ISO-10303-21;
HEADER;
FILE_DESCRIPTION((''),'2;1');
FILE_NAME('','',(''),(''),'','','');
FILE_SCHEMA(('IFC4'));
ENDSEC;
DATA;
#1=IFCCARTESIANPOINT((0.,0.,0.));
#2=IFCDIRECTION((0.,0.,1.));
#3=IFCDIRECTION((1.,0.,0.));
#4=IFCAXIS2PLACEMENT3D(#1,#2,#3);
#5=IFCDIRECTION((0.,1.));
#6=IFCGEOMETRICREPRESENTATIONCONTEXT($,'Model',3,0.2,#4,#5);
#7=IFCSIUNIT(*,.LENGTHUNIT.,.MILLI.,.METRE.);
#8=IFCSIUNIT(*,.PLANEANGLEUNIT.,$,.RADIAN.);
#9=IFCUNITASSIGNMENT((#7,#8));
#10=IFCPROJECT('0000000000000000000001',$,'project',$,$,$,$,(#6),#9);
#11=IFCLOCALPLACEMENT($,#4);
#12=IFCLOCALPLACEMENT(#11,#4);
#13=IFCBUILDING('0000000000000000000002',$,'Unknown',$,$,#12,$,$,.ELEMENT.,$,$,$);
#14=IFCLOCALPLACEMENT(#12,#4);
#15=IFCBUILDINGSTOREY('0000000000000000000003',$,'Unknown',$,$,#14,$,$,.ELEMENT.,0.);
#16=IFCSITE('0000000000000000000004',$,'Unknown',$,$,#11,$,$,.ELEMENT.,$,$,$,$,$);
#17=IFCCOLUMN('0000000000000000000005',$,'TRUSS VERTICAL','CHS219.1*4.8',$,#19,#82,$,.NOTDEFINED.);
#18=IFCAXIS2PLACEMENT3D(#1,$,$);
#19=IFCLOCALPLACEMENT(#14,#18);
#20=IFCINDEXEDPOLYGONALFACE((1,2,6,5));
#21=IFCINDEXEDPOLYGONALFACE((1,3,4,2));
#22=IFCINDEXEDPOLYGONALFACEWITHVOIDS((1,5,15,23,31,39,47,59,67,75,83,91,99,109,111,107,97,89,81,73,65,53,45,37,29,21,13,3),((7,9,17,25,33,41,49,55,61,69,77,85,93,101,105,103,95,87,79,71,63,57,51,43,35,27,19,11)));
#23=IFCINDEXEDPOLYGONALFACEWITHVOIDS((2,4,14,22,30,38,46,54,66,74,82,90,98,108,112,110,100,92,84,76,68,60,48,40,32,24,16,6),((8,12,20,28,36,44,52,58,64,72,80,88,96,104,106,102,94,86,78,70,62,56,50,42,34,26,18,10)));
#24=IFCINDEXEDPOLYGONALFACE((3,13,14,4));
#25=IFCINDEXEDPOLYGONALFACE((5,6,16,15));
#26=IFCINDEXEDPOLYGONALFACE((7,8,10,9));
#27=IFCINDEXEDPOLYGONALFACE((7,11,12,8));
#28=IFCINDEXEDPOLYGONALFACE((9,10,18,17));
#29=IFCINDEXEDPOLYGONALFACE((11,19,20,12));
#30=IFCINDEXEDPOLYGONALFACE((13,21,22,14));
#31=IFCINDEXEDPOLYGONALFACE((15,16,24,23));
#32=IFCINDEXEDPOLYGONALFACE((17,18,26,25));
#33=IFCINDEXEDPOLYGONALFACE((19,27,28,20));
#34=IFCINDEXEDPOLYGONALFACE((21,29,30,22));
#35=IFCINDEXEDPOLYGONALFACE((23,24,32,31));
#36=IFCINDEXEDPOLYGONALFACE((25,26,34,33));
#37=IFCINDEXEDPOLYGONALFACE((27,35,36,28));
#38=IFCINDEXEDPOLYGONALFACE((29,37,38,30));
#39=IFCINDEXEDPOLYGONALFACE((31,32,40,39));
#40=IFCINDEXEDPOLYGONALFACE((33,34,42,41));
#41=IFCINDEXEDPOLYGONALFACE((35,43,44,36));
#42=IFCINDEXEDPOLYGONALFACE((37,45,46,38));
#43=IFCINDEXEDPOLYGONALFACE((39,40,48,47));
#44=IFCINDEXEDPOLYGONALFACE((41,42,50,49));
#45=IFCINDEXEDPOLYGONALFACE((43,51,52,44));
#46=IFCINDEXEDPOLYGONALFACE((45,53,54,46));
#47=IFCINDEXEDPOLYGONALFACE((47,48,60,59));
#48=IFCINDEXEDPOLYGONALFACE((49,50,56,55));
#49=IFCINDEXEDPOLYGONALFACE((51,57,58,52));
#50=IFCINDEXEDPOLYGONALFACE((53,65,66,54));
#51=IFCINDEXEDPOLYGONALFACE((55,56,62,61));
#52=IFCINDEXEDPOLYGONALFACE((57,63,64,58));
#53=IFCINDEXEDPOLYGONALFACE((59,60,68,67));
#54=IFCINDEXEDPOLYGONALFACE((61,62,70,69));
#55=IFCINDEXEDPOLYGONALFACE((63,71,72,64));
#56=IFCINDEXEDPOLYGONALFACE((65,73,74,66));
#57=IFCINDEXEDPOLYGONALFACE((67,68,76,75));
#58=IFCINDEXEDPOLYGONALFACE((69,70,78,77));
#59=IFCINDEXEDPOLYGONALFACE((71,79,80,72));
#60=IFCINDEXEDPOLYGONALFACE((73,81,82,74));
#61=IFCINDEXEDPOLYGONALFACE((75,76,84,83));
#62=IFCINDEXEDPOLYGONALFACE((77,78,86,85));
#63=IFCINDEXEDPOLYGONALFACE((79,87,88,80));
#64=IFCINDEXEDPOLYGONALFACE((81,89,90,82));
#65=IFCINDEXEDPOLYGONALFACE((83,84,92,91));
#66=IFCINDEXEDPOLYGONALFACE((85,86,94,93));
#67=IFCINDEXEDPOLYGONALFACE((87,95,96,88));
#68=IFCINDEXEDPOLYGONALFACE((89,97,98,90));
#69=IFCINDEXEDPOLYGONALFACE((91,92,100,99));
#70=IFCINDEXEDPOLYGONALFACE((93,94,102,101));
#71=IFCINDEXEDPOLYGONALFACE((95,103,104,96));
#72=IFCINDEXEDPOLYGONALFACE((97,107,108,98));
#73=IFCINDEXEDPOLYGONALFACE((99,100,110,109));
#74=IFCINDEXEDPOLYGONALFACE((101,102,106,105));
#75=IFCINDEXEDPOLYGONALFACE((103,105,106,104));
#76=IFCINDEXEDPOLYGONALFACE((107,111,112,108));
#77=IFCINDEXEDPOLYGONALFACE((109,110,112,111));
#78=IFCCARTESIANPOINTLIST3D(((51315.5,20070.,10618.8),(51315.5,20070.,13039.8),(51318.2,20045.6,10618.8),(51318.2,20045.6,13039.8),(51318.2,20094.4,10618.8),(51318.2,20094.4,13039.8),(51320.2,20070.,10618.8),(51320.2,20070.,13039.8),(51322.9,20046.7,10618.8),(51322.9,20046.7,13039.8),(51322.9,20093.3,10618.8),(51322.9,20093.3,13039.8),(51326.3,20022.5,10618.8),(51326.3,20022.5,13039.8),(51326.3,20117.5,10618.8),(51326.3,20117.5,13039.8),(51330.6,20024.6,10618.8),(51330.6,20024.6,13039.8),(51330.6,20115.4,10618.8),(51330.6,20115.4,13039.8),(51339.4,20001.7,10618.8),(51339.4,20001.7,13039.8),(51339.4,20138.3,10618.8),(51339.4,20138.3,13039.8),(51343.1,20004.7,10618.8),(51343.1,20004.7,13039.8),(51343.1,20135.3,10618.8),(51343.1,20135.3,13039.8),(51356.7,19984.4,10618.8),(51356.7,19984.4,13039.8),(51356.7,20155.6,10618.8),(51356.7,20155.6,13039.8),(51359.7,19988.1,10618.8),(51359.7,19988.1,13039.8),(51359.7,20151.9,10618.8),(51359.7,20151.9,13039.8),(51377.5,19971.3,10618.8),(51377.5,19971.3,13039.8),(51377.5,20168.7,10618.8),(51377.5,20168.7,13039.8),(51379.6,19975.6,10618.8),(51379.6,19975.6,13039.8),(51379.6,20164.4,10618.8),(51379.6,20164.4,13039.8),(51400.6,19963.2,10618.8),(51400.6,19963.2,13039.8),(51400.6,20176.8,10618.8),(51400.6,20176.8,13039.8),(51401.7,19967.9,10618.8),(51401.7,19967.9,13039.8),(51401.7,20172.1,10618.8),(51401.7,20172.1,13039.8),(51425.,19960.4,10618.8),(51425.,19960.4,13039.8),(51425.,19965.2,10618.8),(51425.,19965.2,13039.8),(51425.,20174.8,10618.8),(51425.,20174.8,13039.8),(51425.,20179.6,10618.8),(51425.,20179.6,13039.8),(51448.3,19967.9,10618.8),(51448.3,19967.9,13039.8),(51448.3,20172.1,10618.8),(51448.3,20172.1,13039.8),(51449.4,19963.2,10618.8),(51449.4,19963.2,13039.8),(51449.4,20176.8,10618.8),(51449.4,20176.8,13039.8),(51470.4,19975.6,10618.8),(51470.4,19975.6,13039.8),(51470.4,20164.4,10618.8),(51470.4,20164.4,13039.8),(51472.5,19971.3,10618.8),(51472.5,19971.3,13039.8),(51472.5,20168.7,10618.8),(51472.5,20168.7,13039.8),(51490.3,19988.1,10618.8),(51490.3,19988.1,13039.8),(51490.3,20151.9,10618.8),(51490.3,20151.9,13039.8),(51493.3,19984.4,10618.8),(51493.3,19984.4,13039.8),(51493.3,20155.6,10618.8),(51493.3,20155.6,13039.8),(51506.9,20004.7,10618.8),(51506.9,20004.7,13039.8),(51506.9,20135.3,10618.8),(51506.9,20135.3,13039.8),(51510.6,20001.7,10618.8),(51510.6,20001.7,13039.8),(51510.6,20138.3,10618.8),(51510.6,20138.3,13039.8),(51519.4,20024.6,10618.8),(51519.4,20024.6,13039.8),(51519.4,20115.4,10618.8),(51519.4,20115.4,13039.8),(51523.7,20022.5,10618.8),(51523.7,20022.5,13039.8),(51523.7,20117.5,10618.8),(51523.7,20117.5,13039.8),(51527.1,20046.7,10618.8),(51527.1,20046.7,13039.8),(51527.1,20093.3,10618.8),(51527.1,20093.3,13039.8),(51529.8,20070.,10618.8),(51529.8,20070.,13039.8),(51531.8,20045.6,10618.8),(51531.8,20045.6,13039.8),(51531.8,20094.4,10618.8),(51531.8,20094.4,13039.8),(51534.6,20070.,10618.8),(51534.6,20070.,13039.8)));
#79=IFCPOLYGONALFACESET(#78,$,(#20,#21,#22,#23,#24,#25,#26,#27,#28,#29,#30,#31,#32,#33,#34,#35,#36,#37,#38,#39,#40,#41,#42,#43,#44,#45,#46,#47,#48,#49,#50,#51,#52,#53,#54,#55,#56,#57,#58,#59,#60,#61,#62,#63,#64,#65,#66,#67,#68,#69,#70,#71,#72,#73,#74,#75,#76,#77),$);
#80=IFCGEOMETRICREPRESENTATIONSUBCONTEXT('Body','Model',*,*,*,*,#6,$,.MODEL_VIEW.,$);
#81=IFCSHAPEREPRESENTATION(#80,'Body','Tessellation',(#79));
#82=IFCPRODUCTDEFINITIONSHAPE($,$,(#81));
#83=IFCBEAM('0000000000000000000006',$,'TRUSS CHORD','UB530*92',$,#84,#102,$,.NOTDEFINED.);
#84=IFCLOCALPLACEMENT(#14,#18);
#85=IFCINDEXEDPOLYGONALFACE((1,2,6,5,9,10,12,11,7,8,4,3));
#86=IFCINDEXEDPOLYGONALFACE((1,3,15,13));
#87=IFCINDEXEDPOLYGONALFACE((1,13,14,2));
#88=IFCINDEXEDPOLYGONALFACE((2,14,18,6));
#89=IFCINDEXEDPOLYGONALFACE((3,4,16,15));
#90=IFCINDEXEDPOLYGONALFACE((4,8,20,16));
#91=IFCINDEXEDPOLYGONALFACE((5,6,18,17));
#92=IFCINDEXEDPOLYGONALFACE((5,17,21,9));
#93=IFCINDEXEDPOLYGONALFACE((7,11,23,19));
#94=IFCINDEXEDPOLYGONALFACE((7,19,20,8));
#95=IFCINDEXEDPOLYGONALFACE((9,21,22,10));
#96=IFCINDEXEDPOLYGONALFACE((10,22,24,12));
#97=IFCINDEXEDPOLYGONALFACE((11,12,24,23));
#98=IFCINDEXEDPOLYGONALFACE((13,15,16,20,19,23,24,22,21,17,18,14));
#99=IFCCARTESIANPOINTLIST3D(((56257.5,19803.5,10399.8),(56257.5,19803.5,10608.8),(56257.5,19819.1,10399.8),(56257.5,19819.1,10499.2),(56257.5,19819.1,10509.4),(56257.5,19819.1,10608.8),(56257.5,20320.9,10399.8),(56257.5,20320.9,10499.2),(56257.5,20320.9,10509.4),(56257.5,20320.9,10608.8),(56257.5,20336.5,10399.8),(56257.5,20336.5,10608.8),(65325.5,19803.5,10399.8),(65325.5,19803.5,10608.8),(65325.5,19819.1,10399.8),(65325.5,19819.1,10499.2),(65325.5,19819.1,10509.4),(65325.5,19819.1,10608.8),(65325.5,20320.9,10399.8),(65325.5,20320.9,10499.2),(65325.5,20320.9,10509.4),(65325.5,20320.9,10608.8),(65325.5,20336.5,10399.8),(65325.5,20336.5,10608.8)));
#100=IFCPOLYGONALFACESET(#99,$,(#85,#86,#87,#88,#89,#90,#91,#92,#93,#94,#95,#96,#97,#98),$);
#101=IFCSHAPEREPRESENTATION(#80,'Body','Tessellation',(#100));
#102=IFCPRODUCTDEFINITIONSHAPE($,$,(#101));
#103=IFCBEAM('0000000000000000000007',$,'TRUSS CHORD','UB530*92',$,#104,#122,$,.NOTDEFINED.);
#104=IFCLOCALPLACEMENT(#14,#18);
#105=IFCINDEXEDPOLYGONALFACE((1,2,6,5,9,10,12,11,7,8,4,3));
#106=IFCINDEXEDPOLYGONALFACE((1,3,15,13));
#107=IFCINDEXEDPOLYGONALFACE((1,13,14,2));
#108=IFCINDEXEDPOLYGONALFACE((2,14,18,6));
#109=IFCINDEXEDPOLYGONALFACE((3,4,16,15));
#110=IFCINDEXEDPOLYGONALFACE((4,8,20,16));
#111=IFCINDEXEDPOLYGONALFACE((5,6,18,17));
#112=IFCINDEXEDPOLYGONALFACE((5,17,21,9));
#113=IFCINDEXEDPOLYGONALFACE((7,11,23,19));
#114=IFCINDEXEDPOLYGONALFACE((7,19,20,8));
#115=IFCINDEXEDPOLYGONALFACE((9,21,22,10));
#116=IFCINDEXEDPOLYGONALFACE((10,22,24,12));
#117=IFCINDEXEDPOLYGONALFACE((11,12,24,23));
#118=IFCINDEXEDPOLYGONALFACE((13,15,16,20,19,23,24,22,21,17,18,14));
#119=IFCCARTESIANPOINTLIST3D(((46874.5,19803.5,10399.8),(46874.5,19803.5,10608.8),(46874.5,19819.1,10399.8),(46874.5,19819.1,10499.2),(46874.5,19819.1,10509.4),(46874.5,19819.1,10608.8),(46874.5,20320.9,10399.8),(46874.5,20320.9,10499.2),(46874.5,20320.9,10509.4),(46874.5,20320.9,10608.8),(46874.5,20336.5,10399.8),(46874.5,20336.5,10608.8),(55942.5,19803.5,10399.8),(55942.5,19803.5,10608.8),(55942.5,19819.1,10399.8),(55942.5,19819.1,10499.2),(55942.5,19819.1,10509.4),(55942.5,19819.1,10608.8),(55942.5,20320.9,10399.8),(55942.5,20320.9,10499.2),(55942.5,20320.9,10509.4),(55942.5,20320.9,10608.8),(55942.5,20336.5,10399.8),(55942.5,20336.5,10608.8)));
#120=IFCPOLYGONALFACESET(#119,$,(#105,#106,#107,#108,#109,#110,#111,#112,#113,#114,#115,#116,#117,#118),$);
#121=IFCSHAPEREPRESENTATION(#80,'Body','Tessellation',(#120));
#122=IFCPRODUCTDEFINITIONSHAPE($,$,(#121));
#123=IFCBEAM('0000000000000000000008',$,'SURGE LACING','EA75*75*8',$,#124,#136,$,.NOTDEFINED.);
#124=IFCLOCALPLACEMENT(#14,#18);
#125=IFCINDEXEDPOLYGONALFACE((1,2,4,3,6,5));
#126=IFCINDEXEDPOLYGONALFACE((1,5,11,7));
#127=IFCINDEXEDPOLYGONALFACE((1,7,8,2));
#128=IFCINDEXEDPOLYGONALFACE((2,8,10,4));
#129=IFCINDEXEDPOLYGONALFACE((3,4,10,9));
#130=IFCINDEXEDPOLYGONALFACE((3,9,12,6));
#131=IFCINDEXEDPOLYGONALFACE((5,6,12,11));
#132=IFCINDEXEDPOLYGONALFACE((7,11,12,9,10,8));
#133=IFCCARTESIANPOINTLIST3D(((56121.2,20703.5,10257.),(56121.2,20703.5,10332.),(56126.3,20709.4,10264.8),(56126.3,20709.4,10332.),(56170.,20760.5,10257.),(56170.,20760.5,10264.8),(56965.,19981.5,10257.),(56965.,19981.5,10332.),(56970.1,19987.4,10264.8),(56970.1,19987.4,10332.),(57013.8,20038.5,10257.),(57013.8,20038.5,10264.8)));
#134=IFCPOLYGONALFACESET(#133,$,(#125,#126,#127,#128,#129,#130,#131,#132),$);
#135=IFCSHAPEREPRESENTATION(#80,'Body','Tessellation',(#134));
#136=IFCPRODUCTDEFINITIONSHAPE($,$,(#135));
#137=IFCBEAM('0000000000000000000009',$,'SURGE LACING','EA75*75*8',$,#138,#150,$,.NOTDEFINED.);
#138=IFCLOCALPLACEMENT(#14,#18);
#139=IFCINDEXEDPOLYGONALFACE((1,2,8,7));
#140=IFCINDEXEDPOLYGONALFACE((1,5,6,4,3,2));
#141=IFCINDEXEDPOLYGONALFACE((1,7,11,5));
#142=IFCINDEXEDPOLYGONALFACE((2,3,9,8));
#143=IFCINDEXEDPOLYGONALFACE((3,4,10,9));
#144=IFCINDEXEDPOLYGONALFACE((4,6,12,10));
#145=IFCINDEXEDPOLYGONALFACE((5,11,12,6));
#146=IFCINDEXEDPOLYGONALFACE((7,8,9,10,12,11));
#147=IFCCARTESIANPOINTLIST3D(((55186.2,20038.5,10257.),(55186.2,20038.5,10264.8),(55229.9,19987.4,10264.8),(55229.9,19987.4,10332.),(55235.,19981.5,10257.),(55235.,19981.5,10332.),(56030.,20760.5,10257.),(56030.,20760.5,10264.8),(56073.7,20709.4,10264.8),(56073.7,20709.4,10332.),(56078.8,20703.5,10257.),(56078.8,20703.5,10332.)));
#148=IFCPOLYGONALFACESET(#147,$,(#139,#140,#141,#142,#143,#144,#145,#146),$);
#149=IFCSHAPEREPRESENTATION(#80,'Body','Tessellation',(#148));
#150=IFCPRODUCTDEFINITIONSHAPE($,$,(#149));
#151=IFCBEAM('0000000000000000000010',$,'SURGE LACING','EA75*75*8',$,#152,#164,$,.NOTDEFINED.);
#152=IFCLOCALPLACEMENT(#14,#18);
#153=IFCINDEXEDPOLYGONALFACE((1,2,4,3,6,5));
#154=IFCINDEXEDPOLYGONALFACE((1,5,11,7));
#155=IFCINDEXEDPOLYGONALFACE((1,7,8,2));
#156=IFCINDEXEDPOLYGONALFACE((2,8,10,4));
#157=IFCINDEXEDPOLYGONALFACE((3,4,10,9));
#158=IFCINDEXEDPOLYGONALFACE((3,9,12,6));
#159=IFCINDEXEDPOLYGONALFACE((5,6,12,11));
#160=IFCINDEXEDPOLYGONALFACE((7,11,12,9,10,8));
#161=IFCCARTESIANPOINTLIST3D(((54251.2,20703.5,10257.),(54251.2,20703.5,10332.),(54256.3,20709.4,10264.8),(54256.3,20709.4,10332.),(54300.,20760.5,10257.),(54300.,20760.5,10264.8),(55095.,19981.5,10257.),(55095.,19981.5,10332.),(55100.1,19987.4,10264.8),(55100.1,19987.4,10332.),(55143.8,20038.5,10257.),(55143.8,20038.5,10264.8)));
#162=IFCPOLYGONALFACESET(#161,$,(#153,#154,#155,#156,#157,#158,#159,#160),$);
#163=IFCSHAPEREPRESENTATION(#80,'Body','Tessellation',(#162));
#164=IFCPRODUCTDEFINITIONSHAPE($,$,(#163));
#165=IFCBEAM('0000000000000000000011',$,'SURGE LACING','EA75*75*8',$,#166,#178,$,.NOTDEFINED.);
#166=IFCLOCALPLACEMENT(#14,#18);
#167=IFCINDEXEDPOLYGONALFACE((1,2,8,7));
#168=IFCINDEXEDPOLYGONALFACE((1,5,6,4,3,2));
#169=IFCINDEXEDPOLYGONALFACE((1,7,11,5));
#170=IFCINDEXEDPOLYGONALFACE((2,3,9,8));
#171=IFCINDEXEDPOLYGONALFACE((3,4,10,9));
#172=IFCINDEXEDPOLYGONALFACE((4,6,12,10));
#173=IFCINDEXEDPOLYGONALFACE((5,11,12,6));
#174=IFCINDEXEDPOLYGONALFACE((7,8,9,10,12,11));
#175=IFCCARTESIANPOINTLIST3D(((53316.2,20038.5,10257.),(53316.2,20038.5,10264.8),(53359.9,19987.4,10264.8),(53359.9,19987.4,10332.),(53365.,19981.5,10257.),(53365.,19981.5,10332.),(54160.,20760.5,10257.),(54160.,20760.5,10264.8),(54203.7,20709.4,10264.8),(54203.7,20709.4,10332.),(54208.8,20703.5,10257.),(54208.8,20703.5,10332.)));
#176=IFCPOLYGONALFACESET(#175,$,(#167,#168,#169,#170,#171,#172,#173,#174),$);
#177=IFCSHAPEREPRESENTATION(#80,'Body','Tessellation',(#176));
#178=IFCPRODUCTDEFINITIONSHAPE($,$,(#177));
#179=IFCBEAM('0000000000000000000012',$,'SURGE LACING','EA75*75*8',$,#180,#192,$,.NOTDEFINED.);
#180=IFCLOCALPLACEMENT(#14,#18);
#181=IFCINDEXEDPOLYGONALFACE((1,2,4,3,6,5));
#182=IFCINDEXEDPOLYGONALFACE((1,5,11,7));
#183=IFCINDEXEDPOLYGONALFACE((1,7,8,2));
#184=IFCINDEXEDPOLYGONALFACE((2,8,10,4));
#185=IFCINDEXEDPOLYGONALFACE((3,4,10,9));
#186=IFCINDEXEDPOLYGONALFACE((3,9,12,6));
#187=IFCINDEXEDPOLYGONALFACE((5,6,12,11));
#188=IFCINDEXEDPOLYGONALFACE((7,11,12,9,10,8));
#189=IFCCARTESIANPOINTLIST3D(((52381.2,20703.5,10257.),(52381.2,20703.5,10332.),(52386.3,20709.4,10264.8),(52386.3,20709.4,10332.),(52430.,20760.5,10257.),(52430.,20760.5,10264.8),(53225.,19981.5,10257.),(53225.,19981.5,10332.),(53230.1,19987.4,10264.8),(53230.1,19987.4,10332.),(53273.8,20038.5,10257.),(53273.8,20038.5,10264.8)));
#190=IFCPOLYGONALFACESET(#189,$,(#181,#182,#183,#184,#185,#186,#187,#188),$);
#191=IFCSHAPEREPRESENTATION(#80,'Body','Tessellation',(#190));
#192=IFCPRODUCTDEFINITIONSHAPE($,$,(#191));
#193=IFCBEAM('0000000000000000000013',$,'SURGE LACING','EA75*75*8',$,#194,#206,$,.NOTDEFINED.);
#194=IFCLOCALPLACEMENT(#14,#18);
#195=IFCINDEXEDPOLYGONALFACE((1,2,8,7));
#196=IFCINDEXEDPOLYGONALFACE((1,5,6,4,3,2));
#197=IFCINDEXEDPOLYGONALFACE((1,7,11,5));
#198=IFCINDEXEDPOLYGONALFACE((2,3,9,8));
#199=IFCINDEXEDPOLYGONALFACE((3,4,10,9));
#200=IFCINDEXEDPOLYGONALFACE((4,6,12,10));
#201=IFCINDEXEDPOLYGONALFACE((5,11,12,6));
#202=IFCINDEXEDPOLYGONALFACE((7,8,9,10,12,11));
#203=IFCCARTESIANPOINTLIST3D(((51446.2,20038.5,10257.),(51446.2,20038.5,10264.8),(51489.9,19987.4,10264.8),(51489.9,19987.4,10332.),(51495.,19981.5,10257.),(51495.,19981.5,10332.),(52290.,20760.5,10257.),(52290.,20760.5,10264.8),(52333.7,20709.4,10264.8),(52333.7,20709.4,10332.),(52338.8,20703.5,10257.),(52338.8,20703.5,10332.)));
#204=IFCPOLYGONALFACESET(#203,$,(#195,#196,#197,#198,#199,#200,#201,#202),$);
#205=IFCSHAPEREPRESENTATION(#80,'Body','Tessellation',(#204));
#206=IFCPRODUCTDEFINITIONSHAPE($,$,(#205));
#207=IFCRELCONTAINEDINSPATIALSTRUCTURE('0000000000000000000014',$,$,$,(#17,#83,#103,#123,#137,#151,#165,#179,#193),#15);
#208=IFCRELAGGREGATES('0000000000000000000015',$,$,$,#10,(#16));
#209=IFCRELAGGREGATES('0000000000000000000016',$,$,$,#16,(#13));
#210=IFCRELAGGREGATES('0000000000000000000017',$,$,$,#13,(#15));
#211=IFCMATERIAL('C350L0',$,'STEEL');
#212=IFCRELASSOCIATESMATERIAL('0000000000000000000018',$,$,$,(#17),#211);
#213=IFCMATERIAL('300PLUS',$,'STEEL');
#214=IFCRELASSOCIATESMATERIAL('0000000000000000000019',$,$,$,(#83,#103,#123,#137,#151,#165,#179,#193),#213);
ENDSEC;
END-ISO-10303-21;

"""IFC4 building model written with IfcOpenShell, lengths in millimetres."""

from ifc_helpers import new_model, si_unit, direction, frame, origin_with_axes, place, context, subcontext, project, spatial, line, indexed_curve, outline, extrude, material, element, save


model = new_model("IFC4")

# Units and contexts
model_context = context("Model", 3, precision=0.2, world=origin_with_axes(), true_north=direction((0.0, 1.0)))
body_context = subcontext(model_context, "Body", "Model", "MODEL_VIEW")
ifc_project = project(units=[si_unit("LENGTHUNIT", "METRE", prefix="MILLI"), si_unit("PLANEANGLEUNIT", "RADIAN")], contexts=[model_context])

# Site, building, storey
site_placement = place(None, origin_with_axes())
site = spatial("IfcSite", under=ifc_project, at=site_placement, Name="Unknown", CompositionType="ELEMENT")
building_placement = place(site_placement, origin_with_axes())
building = spatial("IfcBuilding", under=site, at=building_placement, Name="Unknown", CompositionType="ELEMENT")
storey_placement = place(building_placement, origin_with_axes())
storey = spatial("IfcBuildingStorey", under=building, at=storey_placement, Name="Unknown", CompositionType="ELEMENT", Elevation=0.0)

# Column
ifc_material_1 = material(Name="C350L0", Category="STEEL")
column_placement = place(storey_placement, frame((51425.0, 20070.0, 10618.8), z_axis=(-1.0, 0.0, 0.0), x_axis=(0.0, 0.0, 1.0)))
element("IfcColumn", 1, at=column_placement, inside=storey, material=ifc_material_1, Name="TRUSS VERTICAL", Description="CHS219.1*4.8", PredefinedType="NOTDEFINED", context=body_context, shape_type="SolidModel", body=[
    extrude(outline(indexed_curve([(109.5, 0.0), (106.8, 24.4), (98.7, 47.5), (85.6, 68.3), (68.3, 85.6), (47.5, 98.7), (24.4, 106.8), (0.0, 109.5), (-24.4, 106.8), (-47.5, 98.7), (-68.3, 85.6), (-85.6, 68.3), (-98.7, 47.5), (-106.8, 24.4), (-109.5, 0.0), (-106.8, -24.4), (-98.7, -47.5), (-85.6, -68.3), (-68.3, -85.6), (-47.5, -98.7), (-24.4, -106.8), (0.0, -109.5), (24.4, -106.8), (47.5, -98.7), (68.3, -85.6), (85.6, -68.3), (98.7, -47.5), (106.8, -24.4)], segments=[line(1, 2, 3, 4, 5, 6, 7, 8, 9, 10, 11, 12, 13, 14, 15, 16, 17, 18, 19, 20, 21, 22, 23, 24, 25, 26, 27, 28, 1)]), holes=[indexed_curve([(104.8, 0.0), (102.1, -23.3), (94.4, -45.4), (81.9, -65.3), (65.3, -81.9), (45.4, -94.4), (23.3, -102.1), (0.0, -104.8), (-23.3, -102.1), (-45.4, -94.4), (-65.3, -81.9), (-81.9, -65.3), (-94.4, -45.4), (-102.1, -23.3), (-104.8, 0.0), (-102.1, 23.3), (-94.4, 45.4), (-81.9, 65.3), (-65.3, 81.9), (-45.4, 94.4), (-23.3, 102.1), (0.0, 104.8), (23.3, 102.1), (45.4, 94.4), (65.3, 81.9), (81.9, 65.3), (94.4, 45.4), (102.1, 23.3)], segments=[line(1, 2, 3, 4, 5, 6, 7, 8, 9, 10, 11, 12, 13, 14, 15, 16, 17, 18, 19, 20, 21, 22, 23, 24, 25, 26, 27, 28, 1)])]), frame((0.0, 0.0, 0.0), z_axis=(-1.0, 0.0, 0.0), x_axis=(0.0, 0.0, 1.0)), (0.0, 0.0, -1.0), 2421.0),
])

# Beams
ifc_material_2 = material(Name="300PLUS", Category="STEEL")
for number, where, z_axis, x_axis, name in (
    (2, (56257.5, 20070.0, 10504.3), (0.0, 0.0, 1.0), (1.0, 0.0, 0.0), "TRUSS CHORD"),
    (3, (46874.5, 20070.0, 10504.3), (0.0, 0.0, 1.0), (1.0, 0.0, 0.0), "TRUSS CHORD"),
):
    element("IfcBeam", number, at=place(storey_placement, frame(where, z_axis=z_axis, x_axis=x_axis)), inside=storey, material=ifc_material_2, Name=name, Description="UB530*92", PredefinedType="NOTDEFINED", context=body_context, shape_type="SolidModel", body=[
        extrude(outline(indexed_curve([(-104.5, -266.5), (104.5, -266.5), (104.5, -250.9), (5.1, -250.9), (5.1, 250.9), (104.5, 250.9), (104.5, 266.5), (-104.5, 266.5), (-104.5, 250.9), (-5.1, 250.9), (-5.1, -250.9), (-104.5, -250.9)], segments=[line(1, 2, 3, 4, 5, 6, 7, 8, 9, 10, 11, 12, 1)])), frame((0.0, 0.0, 0.0), z_axis=(-1.0, 0.0, 0.0), x_axis=(0.0, 0.0, 1.0)), (0.0, 0.0, -1.0), 9068.0),
    ])
for number, where, z_axis, x_axis, name in (
    (4, (56145.6, 20732.0, 10294.5), (0.0, 0.0, 1.0), (0.759816, -0.650139, 0.0), "SURGE LACING"),
    (5, (55210.6, 20010.0, 10294.5), (0.0, 0.0, 1.0), (0.759816, 0.650139, 0.0), "SURGE LACING"),
    (6, (54275.6, 20732.0, 10294.5), (0.0, 0.0, 1.0), (0.759816, -0.650139, 0.0), "SURGE LACING"),
    (7, (53340.6, 20010.0, 10294.5), (0.0, 0.0, 1.0), (0.759816, 0.650139, 0.0), "SURGE LACING"),
    (8, (52405.6, 20732.0, 10294.5), (0.0, 0.0, 1.0), (0.759816, -0.650139, 0.0), "SURGE LACING"),
    (9, (51470.6, 20010.0, 10294.5), (0.0, 0.0, 1.0), (0.759816, 0.650139, 0.0), "SURGE LACING"),
):
    element("IfcBeam", number, at=place(storey_placement, frame(where, z_axis=z_axis, x_axis=x_axis)), inside=storey, material=ifc_material_2, Name=name, Description="EA75*75*8", PredefinedType="NOTDEFINED", context=body_context, shape_type="SolidModel", body=[
        extrude(outline(indexed_curve([(-37.5, -37.5), (37.5, -37.5), (37.5, -29.7), (-29.7, -29.7), (-29.7, 37.5), (-37.5, 37.5)], segments=[line(1, 2, 3, 4, 5, 6, 1)])), frame((0.0, 0.0, 0.0), z_axis=(-1.0, 0.0, 0.0), x_axis=(0.0, 0.0, 1.0)), (0.0, 0.0, -1.0), 1110.5),
    ])

save(model, "model.ifc")
